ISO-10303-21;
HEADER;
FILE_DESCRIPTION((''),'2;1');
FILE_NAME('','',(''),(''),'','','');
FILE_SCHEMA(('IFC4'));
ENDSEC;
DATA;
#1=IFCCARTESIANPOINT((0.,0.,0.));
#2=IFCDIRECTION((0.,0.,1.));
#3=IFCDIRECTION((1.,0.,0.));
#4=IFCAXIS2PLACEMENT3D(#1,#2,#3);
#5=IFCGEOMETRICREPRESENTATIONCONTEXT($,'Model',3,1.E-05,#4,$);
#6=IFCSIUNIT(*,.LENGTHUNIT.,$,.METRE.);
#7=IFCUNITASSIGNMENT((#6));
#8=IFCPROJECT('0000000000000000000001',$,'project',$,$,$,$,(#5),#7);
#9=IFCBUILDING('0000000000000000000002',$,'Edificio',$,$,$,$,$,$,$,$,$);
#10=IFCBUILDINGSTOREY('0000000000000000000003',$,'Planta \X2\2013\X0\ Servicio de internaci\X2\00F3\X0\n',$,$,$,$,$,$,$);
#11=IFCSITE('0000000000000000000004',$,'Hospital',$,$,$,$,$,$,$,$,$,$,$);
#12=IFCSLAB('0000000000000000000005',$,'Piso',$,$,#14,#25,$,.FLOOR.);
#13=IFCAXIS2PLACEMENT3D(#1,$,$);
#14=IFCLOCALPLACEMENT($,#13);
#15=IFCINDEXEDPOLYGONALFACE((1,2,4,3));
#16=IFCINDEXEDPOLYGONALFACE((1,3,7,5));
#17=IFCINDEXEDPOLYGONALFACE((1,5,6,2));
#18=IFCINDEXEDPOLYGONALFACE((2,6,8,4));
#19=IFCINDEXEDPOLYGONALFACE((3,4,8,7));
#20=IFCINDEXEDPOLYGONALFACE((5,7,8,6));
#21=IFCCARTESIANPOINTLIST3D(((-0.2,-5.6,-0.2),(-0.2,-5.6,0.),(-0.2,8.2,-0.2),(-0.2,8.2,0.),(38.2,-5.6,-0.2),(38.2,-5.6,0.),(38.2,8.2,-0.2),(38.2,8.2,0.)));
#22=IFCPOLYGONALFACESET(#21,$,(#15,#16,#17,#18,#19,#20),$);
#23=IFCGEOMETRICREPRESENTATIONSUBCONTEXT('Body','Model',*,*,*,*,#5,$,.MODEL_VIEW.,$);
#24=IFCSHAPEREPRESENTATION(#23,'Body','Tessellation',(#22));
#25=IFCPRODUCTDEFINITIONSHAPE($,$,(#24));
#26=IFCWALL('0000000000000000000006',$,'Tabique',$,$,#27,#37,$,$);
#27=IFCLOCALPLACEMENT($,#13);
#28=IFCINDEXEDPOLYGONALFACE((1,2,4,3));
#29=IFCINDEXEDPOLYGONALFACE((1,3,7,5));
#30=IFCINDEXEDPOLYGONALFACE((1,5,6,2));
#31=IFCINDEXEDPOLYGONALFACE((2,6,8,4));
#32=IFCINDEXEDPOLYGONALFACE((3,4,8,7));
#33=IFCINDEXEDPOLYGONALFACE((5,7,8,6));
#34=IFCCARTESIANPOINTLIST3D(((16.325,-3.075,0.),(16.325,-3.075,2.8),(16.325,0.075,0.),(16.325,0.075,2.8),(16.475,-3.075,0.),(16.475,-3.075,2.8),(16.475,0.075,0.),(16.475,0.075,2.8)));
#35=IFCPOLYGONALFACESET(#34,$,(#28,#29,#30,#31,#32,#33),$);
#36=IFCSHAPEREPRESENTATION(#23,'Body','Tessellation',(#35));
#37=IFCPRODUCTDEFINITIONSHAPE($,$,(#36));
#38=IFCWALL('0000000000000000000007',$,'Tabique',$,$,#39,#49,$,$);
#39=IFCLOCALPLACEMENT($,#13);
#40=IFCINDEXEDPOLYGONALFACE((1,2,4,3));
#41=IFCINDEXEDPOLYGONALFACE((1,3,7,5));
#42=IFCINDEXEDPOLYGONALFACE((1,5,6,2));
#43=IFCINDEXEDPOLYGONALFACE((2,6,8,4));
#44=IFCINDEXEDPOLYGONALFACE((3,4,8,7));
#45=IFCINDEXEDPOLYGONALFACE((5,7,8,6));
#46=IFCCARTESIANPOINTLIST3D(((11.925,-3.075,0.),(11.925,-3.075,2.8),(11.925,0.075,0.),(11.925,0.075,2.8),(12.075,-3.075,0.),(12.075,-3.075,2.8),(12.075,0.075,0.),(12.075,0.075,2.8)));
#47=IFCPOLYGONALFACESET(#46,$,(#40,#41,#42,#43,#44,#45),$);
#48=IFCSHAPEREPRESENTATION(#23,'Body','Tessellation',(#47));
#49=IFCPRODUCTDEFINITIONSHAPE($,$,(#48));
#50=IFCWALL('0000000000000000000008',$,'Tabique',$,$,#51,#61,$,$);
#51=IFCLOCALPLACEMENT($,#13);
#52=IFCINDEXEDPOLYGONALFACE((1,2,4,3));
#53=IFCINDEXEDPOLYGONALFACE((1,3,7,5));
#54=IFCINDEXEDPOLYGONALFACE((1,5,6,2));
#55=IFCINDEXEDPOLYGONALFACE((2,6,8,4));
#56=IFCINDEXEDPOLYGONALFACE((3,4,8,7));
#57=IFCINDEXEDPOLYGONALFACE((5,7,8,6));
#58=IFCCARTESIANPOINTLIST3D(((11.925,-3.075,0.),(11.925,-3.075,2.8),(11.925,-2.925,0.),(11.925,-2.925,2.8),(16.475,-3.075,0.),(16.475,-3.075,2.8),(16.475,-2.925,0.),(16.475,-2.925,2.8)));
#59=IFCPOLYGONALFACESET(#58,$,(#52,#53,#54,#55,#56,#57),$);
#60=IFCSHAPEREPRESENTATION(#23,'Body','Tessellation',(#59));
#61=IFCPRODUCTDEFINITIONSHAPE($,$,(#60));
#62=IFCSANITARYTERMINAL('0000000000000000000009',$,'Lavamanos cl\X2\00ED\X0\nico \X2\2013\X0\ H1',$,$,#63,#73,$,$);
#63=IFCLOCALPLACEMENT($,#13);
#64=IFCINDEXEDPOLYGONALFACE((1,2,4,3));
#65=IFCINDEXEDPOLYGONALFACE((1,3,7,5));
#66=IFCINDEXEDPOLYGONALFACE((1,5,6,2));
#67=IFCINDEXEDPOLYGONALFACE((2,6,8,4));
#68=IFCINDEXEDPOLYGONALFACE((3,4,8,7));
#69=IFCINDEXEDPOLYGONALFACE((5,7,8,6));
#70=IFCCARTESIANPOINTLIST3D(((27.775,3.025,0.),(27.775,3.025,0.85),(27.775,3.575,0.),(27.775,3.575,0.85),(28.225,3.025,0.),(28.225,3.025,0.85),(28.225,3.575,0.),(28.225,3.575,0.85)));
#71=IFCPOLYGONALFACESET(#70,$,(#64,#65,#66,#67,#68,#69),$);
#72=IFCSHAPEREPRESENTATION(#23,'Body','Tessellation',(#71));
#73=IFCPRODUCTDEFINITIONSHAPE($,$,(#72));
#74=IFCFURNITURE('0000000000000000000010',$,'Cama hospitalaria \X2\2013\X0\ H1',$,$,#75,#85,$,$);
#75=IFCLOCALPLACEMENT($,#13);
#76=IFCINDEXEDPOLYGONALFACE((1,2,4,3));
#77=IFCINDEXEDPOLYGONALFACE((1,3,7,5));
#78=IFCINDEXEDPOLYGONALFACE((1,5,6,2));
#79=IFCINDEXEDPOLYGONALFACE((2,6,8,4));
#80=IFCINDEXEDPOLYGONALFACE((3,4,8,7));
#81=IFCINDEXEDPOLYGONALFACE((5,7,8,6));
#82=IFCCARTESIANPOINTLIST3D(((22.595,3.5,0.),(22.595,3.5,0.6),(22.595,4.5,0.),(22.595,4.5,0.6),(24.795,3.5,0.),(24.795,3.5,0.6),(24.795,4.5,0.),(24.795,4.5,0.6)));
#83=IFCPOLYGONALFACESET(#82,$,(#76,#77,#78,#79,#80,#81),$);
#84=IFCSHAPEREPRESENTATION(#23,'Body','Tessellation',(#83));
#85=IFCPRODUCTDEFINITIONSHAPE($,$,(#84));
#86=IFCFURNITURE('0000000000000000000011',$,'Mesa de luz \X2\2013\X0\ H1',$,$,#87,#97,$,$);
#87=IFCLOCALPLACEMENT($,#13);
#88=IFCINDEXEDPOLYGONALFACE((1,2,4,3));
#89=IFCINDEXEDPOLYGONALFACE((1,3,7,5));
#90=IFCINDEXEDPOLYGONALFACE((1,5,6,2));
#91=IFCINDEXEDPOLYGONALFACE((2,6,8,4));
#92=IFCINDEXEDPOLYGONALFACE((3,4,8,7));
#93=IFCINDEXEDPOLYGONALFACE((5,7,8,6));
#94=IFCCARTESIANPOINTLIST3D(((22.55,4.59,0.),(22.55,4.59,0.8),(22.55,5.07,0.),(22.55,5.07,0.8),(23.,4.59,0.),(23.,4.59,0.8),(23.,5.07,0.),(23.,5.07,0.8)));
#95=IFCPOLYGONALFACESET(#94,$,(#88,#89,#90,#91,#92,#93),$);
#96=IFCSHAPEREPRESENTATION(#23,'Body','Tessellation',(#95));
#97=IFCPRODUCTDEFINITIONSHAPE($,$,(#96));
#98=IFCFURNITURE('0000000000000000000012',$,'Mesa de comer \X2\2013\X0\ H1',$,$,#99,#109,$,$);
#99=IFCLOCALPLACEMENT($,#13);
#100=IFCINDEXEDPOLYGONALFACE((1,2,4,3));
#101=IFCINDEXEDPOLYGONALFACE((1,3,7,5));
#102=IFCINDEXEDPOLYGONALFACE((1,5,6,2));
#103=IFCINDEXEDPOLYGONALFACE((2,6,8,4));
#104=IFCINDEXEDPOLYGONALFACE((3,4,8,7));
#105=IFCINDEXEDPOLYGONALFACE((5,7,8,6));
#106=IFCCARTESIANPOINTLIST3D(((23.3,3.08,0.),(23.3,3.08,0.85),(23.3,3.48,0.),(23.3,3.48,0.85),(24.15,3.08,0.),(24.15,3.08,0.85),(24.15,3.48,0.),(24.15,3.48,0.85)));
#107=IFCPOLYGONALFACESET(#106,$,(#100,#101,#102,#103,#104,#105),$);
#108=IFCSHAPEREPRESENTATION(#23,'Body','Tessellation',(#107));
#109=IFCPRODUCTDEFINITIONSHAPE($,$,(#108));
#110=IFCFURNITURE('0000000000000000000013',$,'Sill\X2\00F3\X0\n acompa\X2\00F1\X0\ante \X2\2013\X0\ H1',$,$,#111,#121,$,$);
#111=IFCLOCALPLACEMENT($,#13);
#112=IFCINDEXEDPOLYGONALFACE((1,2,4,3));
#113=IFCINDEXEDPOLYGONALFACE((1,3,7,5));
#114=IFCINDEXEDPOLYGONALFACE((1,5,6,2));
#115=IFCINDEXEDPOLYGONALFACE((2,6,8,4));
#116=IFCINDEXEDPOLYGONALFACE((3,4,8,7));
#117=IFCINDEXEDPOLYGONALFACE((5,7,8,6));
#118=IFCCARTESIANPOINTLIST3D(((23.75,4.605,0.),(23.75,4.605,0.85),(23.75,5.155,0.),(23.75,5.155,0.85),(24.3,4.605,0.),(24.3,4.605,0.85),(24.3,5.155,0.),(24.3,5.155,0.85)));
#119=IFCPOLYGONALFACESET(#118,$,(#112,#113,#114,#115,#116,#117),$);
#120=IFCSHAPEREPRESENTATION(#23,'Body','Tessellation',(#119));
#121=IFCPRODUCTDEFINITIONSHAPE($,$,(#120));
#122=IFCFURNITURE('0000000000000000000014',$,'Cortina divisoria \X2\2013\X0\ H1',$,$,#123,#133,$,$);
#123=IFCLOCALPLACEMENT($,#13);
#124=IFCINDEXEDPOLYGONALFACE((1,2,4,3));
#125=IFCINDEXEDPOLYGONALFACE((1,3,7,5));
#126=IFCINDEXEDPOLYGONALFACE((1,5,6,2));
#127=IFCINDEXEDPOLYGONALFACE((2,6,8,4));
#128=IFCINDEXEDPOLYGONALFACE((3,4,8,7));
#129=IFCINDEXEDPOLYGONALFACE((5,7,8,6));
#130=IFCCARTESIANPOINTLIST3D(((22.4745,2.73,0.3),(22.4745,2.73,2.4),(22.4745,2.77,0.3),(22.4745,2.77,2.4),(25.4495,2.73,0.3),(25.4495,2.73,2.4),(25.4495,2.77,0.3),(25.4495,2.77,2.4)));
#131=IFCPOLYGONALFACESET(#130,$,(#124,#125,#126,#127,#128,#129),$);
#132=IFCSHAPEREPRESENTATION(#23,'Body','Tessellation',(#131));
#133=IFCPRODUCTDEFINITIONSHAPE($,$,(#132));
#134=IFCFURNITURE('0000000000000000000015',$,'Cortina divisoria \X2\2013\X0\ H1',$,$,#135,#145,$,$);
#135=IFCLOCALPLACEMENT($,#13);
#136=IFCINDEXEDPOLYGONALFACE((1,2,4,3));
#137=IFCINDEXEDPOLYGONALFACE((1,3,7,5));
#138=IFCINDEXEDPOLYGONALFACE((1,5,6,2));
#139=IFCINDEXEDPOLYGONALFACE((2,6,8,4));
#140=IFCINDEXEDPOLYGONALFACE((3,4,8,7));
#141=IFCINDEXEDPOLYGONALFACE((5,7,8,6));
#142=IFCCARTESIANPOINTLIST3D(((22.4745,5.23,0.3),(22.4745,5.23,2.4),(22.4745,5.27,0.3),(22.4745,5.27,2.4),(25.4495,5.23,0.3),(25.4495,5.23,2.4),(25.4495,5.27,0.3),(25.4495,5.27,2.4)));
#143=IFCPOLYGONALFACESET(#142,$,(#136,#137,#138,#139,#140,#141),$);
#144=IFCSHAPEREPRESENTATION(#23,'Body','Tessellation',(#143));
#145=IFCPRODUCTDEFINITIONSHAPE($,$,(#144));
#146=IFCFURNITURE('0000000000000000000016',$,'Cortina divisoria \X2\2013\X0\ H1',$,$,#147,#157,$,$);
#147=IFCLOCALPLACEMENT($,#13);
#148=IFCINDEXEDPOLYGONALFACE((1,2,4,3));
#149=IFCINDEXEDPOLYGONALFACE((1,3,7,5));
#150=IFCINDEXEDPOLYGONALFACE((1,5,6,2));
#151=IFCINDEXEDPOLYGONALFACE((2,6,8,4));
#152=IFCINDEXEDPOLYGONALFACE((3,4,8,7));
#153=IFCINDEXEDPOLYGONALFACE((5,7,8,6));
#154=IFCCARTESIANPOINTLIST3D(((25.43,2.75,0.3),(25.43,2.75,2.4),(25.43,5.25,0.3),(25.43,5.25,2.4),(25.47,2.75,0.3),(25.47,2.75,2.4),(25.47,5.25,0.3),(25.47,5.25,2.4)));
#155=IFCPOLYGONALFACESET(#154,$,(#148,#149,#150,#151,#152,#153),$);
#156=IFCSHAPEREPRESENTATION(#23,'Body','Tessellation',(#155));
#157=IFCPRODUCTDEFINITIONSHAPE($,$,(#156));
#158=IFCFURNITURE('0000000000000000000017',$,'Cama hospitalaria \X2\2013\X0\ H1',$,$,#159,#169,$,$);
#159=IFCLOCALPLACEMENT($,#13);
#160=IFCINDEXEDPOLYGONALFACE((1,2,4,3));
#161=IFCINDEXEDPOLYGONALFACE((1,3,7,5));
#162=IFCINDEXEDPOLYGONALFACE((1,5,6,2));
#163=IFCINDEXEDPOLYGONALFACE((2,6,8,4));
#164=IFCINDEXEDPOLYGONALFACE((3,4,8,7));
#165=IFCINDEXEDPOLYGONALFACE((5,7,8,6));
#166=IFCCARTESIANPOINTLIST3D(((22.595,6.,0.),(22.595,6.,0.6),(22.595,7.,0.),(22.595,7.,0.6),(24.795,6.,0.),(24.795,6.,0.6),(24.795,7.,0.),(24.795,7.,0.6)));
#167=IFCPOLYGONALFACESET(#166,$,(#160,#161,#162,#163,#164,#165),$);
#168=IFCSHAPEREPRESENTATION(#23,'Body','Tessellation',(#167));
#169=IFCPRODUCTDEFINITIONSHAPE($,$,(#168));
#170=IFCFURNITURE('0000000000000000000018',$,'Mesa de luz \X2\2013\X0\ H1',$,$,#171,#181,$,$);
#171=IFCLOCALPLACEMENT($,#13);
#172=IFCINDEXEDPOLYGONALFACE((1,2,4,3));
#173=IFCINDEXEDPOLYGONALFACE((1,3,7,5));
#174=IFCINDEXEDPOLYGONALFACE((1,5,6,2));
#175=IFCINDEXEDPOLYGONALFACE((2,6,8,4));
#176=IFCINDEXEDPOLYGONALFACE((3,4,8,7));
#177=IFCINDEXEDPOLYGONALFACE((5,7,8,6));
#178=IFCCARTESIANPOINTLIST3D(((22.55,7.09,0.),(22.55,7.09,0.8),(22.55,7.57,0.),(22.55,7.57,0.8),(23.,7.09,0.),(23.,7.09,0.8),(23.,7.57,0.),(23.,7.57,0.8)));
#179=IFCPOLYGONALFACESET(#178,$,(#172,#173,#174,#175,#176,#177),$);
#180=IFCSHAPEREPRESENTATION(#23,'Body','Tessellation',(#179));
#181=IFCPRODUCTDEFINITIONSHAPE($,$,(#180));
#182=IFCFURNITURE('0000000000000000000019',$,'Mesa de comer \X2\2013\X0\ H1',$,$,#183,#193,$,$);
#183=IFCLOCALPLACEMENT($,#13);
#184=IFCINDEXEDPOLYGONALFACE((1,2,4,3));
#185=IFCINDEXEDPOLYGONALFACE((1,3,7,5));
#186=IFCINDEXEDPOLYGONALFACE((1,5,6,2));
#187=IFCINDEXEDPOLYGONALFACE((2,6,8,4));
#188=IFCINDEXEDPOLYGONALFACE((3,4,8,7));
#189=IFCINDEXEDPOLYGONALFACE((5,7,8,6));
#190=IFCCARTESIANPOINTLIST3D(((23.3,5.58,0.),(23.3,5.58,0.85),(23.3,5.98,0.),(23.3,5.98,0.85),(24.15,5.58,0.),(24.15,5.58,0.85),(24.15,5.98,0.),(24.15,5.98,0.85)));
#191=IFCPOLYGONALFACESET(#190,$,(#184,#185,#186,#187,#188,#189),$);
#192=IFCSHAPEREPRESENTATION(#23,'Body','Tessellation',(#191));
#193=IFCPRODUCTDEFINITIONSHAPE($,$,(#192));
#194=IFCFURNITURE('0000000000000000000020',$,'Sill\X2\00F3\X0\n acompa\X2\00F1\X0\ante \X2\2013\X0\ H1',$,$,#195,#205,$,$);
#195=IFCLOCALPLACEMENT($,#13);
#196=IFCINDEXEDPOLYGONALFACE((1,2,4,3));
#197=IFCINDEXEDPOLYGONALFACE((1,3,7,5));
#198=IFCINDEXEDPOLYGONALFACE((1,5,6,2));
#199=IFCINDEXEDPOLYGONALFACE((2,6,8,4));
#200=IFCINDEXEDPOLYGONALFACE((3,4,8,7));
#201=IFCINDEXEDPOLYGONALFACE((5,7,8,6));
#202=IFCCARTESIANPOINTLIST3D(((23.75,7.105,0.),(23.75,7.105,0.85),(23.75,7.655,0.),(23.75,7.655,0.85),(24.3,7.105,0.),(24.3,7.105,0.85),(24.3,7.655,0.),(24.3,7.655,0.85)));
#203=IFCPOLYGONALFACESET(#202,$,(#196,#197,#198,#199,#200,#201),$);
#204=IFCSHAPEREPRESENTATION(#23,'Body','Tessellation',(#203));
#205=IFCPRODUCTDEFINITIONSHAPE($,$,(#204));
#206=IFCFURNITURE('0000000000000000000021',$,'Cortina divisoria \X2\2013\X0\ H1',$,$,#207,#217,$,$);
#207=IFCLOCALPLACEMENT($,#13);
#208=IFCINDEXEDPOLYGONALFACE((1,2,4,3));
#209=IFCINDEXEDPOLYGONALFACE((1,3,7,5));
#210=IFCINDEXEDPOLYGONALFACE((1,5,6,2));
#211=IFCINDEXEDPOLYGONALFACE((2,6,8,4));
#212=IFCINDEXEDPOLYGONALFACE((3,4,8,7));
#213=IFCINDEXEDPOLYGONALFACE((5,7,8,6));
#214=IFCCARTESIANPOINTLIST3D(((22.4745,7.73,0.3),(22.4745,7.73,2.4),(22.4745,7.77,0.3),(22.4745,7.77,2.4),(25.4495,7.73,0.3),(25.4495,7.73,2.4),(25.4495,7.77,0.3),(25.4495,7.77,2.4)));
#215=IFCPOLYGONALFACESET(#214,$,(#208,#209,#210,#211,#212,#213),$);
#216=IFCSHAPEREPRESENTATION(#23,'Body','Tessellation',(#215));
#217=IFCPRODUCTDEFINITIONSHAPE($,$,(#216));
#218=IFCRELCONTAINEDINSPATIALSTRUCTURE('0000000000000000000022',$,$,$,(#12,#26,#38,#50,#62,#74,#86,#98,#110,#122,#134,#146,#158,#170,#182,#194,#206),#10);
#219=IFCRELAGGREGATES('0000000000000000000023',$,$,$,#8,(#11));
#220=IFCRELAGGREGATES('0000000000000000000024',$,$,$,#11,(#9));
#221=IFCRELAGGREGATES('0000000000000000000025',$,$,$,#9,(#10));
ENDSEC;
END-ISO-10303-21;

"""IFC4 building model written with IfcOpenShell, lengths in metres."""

from ifc_helpers import new_model, si_unit, frame, origin_with_axes, context, subcontext, project, spatial, line, indexed_curve, outline, extrude, element, save


model = new_model("IFC4")

# Units and contexts
model_context = context("Model", 3, precision=1e-05, world=origin_with_axes())
body_context = subcontext(model_context, "Body", "Model", "MODEL_VIEW")
ifc_project = project(units=[si_unit("LENGTHUNIT", "METRE")], contexts=[model_context])

# Site, building, storey
site = spatial("IfcSite", under=ifc_project, Name="Hospital")
building = spatial("IfcBuilding", under=site, Name="Edificio")
storey = spatial("IfcBuildingStorey", under=building, Name="Planta – Servicio de internación")

# Slab
element("IfcSlab", 1, inside=storey, Name="Piso", PredefinedType="FLOOR", context=body_context, shape_type="SweptSolid", body=[
    extrude(outline(indexed_curve([(0.0, 0.0), (38.4, 0.0), (38.4, 13.8), (0.0, 13.8)], segments=[line(1, 2, 3, 4, 1)])), frame((-0.2, -5.6, -0.2), z_axis=(0.0, 0.0, 1.0), x_axis=(1.0, 0.0, 0.0)), (0.0, 0.0, 1.0), 0.2),
])

# Walls
element("IfcWall", 2, inside=storey, Name="Tabique", context=body_context, shape_type="SweptSolid", body=[
    extrude(outline(indexed_curve([(0.0, 0.0), (0.15, 0.0), (0.15, 3.15), (0.0, 3.15)], segments=[line(1, 2, 3, 4, 1)])), frame((16.325, -3.075, 0.0), z_axis=(0.0, 0.0, 1.0), x_axis=(1.0, 0.0, 0.0)), (0.0, 0.0, 1.0), 2.8),
])
element("IfcWall", 3, inside=storey, Name="Tabique", context=body_context, shape_type="SweptSolid", body=[
    extrude(outline(indexed_curve([(0.0, 0.0), (0.15, 0.0), (0.15, 3.15), (0.0, 3.15)], segments=[line(1, 2, 3, 4, 1)])), frame((11.925, -3.075, 0.0), z_axis=(0.0, 0.0, 1.0), x_axis=(1.0, 0.0, 0.0)), (0.0, 0.0, 1.0), 2.8),
])
element("IfcWall", 4, inside=storey, Name="Tabique", context=body_context, shape_type="SweptSolid", body=[
    extrude(outline(indexed_curve([(0.0, 0.0), (4.55, 0.0), (4.55, 0.15), (0.0, 0.15)], segments=[line(1, 2, 3, 4, 1)])), frame((11.925, -3.075, 0.0), z_axis=(0.0, 0.0, 1.0), x_axis=(1.0, 0.0, 0.0)), (0.0, 0.0, 1.0), 2.8),
])

# Sanitary terminal
element("IfcSanitaryTerminal", 5, inside=storey, Name="Lavamanos clínico – H1", context=body_context, shape_type="SweptSolid", body=[
    extrude(outline(indexed_curve([(0.0, 0.0), (0.45, 0.0), (0.45, 0.55), (0.0, 0.55)], segments=[line(1, 2, 3, 4, 1)])), frame((27.775, 3.025, 0.0), z_axis=(0.0, 0.0, 1.0), x_axis=(1.0, 0.0, 0.0)), (0.0, 0.0, 1.0), 0.85),
])

# Furniture
element("IfcFurniture", 6, inside=storey, Name="Cama hospitalaria – H1", context=body_context, shape_type="SweptSolid", body=[
    extrude(outline(indexed_curve([(0.0, 0.0), (2.2, 0.0), (2.2, 1.0), (0.0, 1.0)], segments=[line(1, 2, 3, 4, 1)])), frame((22.595, 3.5, 0.0), z_axis=(0.0, 0.0, 1.0), x_axis=(1.0, 0.0, 0.0)), (0.0, 0.0, 1.0), 0.6),
])
element("IfcFurniture", 7, inside=storey, Name="Mesa de luz – H1", context=body_context, shape_type="SweptSolid", body=[
    extrude(outline(indexed_curve([(0.0, 0.0), (0.45, 0.0), (0.45, 0.48), (0.0, 0.48)], segments=[line(1, 2, 3, 4, 1)])), frame((22.55, 4.59, 0.0), z_axis=(0.0, 0.0, 1.0), x_axis=(1.0, 0.0, 0.0)), (0.0, 0.0, 1.0), 0.8),
])
element("IfcFurniture", 8, inside=storey, Name="Mesa de comer – H1", context=body_context, shape_type="SweptSolid", body=[
    extrude(outline(indexed_curve([(0.0, 0.0), (0.85, 0.0), (0.85, 0.4), (0.0, 0.4)], segments=[line(1, 2, 3, 4, 1)])), frame((23.3, 3.08, 0.0), z_axis=(0.0, 0.0, 1.0), x_axis=(1.0, 0.0, 0.0)), (0.0, 0.0, 1.0), 0.85),
])
element("IfcFurniture", 9, inside=storey, Name="Sillón acompañante – H1", context=body_context, shape_type="SweptSolid", body=[
    extrude(outline(indexed_curve([(0.0, 0.0), (0.55, 0.0), (0.55, 0.55), (0.0, 0.55)], segments=[line(1, 2, 3, 4, 1)])), frame((23.75, 4.605, 0.0), z_axis=(0.0, 0.0, 1.0), x_axis=(1.0, 0.0, 0.0)), (0.0, 0.0, 1.0), 0.85),
])
element("IfcFurniture", 10, inside=storey, Name="Cortina divisoria – H1", context=body_context, shape_type="SweptSolid", body=[
    extrude(outline(indexed_curve([(0.0, 0.0), (2.975, 0.0), (2.975, 0.04), (0.0, 0.04)], segments=[line(1, 2, 3, 4, 1)])), frame((22.4745, 2.73, 0.3), z_axis=(0.0, 0.0, 1.0), x_axis=(1.0, 0.0, 0.0)), (0.0, 0.0, 1.0), 2.1),
])
element("IfcFurniture", 11, inside=storey, Name="Cortina divisoria – H1", context=body_context, shape_type="SweptSolid", body=[
    extrude(outline(indexed_curve([(0.0, 0.0), (2.975, 0.0), (2.975, 0.04), (0.0, 0.04)], segments=[line(1, 2, 3, 4, 1)])), frame((22.4745, 5.23, 0.3), z_axis=(0.0, 0.0, 1.0), x_axis=(1.0, 0.0, 0.0)), (0.0, 0.0, 1.0), 2.1),
])
element("IfcFurniture", 12, inside=storey, Name="Cortina divisoria – H1", context=body_context, shape_type="SweptSolid", body=[
    extrude(outline(indexed_curve([(0.0, 0.0), (0.04, 0.0), (0.04, 2.5), (0.0, 2.5)], segments=[line(1, 2, 3, 4, 1)])), frame((25.43, 2.75, 0.3), z_axis=(0.0, 0.0, 1.0), x_axis=(1.0, 0.0, 0.0)), (0.0, 0.0, 1.0), 2.1),
])
element("IfcFurniture", 13, inside=storey, Name="Cama hospitalaria – H1", context=body_context, shape_type="SweptSolid", body=[
    extrude(outline(indexed_curve([(0.0, 0.0), (2.2, 0.0), (2.2, 1.0), (0.0, 1.0)], segments=[line(1, 2, 3, 4, 1)])), frame((22.595, 6.0, 0.0), z_axis=(0.0, 0.0, 1.0), x_axis=(1.0, 0.0, 0.0)), (0.0, 0.0, 1.0), 0.6),
])
element("IfcFurniture", 14, inside=storey, Name="Mesa de luz – H1", context=body_context, shape_type="SweptSolid", body=[
    extrude(outline(indexed_curve([(0.0, 0.0), (0.45, 0.0), (0.45, 0.48), (0.0, 0.48)], segments=[line(1, 2, 3, 4, 1)])), frame((22.55, 7.09, 0.0), z_axis=(0.0, 0.0, 1.0), x_axis=(1.0, 0.0, 0.0)), (0.0, 0.0, 1.0), 0.8),
])
element("IfcFurniture", 15, inside=storey, Name="Mesa de comer – H1", context=body_context, shape_type="SweptSolid", body=[
    extrude(outline(indexed_curve([(0.0, 0.0), (0.85, 0.0), (0.85, 0.4), (0.0, 0.4)], segments=[line(1, 2, 3, 4, 1)])), frame((23.3, 5.58, 0.0), z_axis=(0.0, 0.0, 1.0), x_axis=(1.0, 0.0, 0.0)), (0.0, 0.0, 1.0), 0.85),
])
element("IfcFurniture", 16, inside=storey, Name="Sillón acompañante – H1", context=body_context, shape_type="SweptSolid", body=[
    extrude(outline(indexed_curve([(0.0, 0.0), (0.55, 0.0), (0.55, 0.55), (0.0, 0.55)], segments=[line(1, 2, 3, 4, 1)])), frame((23.75, 7.105, 0.0), z_axis=(0.0, 0.0, 1.0), x_axis=(1.0, 0.0, 0.0)), (0.0, 0.0, 1.0), 0.85),
])
element("IfcFurniture", 17, inside=storey, Name="Cortina divisoria – H1", context=body_context, shape_type="SweptSolid", body=[
    extrude(outline(indexed_curve([(0.0, 0.0), (2.975, 0.0), (2.975, 0.04), (0.0, 0.04)], segments=[line(1, 2, 3, 4, 1)])), frame((22.4745, 7.73, 0.3), z_axis=(0.0, 0.0, 1.0), x_axis=(1.0, 0.0, 0.0)), (0.0, 0.0, 1.0), 2.1),
])

save(model, "model.ifc")
